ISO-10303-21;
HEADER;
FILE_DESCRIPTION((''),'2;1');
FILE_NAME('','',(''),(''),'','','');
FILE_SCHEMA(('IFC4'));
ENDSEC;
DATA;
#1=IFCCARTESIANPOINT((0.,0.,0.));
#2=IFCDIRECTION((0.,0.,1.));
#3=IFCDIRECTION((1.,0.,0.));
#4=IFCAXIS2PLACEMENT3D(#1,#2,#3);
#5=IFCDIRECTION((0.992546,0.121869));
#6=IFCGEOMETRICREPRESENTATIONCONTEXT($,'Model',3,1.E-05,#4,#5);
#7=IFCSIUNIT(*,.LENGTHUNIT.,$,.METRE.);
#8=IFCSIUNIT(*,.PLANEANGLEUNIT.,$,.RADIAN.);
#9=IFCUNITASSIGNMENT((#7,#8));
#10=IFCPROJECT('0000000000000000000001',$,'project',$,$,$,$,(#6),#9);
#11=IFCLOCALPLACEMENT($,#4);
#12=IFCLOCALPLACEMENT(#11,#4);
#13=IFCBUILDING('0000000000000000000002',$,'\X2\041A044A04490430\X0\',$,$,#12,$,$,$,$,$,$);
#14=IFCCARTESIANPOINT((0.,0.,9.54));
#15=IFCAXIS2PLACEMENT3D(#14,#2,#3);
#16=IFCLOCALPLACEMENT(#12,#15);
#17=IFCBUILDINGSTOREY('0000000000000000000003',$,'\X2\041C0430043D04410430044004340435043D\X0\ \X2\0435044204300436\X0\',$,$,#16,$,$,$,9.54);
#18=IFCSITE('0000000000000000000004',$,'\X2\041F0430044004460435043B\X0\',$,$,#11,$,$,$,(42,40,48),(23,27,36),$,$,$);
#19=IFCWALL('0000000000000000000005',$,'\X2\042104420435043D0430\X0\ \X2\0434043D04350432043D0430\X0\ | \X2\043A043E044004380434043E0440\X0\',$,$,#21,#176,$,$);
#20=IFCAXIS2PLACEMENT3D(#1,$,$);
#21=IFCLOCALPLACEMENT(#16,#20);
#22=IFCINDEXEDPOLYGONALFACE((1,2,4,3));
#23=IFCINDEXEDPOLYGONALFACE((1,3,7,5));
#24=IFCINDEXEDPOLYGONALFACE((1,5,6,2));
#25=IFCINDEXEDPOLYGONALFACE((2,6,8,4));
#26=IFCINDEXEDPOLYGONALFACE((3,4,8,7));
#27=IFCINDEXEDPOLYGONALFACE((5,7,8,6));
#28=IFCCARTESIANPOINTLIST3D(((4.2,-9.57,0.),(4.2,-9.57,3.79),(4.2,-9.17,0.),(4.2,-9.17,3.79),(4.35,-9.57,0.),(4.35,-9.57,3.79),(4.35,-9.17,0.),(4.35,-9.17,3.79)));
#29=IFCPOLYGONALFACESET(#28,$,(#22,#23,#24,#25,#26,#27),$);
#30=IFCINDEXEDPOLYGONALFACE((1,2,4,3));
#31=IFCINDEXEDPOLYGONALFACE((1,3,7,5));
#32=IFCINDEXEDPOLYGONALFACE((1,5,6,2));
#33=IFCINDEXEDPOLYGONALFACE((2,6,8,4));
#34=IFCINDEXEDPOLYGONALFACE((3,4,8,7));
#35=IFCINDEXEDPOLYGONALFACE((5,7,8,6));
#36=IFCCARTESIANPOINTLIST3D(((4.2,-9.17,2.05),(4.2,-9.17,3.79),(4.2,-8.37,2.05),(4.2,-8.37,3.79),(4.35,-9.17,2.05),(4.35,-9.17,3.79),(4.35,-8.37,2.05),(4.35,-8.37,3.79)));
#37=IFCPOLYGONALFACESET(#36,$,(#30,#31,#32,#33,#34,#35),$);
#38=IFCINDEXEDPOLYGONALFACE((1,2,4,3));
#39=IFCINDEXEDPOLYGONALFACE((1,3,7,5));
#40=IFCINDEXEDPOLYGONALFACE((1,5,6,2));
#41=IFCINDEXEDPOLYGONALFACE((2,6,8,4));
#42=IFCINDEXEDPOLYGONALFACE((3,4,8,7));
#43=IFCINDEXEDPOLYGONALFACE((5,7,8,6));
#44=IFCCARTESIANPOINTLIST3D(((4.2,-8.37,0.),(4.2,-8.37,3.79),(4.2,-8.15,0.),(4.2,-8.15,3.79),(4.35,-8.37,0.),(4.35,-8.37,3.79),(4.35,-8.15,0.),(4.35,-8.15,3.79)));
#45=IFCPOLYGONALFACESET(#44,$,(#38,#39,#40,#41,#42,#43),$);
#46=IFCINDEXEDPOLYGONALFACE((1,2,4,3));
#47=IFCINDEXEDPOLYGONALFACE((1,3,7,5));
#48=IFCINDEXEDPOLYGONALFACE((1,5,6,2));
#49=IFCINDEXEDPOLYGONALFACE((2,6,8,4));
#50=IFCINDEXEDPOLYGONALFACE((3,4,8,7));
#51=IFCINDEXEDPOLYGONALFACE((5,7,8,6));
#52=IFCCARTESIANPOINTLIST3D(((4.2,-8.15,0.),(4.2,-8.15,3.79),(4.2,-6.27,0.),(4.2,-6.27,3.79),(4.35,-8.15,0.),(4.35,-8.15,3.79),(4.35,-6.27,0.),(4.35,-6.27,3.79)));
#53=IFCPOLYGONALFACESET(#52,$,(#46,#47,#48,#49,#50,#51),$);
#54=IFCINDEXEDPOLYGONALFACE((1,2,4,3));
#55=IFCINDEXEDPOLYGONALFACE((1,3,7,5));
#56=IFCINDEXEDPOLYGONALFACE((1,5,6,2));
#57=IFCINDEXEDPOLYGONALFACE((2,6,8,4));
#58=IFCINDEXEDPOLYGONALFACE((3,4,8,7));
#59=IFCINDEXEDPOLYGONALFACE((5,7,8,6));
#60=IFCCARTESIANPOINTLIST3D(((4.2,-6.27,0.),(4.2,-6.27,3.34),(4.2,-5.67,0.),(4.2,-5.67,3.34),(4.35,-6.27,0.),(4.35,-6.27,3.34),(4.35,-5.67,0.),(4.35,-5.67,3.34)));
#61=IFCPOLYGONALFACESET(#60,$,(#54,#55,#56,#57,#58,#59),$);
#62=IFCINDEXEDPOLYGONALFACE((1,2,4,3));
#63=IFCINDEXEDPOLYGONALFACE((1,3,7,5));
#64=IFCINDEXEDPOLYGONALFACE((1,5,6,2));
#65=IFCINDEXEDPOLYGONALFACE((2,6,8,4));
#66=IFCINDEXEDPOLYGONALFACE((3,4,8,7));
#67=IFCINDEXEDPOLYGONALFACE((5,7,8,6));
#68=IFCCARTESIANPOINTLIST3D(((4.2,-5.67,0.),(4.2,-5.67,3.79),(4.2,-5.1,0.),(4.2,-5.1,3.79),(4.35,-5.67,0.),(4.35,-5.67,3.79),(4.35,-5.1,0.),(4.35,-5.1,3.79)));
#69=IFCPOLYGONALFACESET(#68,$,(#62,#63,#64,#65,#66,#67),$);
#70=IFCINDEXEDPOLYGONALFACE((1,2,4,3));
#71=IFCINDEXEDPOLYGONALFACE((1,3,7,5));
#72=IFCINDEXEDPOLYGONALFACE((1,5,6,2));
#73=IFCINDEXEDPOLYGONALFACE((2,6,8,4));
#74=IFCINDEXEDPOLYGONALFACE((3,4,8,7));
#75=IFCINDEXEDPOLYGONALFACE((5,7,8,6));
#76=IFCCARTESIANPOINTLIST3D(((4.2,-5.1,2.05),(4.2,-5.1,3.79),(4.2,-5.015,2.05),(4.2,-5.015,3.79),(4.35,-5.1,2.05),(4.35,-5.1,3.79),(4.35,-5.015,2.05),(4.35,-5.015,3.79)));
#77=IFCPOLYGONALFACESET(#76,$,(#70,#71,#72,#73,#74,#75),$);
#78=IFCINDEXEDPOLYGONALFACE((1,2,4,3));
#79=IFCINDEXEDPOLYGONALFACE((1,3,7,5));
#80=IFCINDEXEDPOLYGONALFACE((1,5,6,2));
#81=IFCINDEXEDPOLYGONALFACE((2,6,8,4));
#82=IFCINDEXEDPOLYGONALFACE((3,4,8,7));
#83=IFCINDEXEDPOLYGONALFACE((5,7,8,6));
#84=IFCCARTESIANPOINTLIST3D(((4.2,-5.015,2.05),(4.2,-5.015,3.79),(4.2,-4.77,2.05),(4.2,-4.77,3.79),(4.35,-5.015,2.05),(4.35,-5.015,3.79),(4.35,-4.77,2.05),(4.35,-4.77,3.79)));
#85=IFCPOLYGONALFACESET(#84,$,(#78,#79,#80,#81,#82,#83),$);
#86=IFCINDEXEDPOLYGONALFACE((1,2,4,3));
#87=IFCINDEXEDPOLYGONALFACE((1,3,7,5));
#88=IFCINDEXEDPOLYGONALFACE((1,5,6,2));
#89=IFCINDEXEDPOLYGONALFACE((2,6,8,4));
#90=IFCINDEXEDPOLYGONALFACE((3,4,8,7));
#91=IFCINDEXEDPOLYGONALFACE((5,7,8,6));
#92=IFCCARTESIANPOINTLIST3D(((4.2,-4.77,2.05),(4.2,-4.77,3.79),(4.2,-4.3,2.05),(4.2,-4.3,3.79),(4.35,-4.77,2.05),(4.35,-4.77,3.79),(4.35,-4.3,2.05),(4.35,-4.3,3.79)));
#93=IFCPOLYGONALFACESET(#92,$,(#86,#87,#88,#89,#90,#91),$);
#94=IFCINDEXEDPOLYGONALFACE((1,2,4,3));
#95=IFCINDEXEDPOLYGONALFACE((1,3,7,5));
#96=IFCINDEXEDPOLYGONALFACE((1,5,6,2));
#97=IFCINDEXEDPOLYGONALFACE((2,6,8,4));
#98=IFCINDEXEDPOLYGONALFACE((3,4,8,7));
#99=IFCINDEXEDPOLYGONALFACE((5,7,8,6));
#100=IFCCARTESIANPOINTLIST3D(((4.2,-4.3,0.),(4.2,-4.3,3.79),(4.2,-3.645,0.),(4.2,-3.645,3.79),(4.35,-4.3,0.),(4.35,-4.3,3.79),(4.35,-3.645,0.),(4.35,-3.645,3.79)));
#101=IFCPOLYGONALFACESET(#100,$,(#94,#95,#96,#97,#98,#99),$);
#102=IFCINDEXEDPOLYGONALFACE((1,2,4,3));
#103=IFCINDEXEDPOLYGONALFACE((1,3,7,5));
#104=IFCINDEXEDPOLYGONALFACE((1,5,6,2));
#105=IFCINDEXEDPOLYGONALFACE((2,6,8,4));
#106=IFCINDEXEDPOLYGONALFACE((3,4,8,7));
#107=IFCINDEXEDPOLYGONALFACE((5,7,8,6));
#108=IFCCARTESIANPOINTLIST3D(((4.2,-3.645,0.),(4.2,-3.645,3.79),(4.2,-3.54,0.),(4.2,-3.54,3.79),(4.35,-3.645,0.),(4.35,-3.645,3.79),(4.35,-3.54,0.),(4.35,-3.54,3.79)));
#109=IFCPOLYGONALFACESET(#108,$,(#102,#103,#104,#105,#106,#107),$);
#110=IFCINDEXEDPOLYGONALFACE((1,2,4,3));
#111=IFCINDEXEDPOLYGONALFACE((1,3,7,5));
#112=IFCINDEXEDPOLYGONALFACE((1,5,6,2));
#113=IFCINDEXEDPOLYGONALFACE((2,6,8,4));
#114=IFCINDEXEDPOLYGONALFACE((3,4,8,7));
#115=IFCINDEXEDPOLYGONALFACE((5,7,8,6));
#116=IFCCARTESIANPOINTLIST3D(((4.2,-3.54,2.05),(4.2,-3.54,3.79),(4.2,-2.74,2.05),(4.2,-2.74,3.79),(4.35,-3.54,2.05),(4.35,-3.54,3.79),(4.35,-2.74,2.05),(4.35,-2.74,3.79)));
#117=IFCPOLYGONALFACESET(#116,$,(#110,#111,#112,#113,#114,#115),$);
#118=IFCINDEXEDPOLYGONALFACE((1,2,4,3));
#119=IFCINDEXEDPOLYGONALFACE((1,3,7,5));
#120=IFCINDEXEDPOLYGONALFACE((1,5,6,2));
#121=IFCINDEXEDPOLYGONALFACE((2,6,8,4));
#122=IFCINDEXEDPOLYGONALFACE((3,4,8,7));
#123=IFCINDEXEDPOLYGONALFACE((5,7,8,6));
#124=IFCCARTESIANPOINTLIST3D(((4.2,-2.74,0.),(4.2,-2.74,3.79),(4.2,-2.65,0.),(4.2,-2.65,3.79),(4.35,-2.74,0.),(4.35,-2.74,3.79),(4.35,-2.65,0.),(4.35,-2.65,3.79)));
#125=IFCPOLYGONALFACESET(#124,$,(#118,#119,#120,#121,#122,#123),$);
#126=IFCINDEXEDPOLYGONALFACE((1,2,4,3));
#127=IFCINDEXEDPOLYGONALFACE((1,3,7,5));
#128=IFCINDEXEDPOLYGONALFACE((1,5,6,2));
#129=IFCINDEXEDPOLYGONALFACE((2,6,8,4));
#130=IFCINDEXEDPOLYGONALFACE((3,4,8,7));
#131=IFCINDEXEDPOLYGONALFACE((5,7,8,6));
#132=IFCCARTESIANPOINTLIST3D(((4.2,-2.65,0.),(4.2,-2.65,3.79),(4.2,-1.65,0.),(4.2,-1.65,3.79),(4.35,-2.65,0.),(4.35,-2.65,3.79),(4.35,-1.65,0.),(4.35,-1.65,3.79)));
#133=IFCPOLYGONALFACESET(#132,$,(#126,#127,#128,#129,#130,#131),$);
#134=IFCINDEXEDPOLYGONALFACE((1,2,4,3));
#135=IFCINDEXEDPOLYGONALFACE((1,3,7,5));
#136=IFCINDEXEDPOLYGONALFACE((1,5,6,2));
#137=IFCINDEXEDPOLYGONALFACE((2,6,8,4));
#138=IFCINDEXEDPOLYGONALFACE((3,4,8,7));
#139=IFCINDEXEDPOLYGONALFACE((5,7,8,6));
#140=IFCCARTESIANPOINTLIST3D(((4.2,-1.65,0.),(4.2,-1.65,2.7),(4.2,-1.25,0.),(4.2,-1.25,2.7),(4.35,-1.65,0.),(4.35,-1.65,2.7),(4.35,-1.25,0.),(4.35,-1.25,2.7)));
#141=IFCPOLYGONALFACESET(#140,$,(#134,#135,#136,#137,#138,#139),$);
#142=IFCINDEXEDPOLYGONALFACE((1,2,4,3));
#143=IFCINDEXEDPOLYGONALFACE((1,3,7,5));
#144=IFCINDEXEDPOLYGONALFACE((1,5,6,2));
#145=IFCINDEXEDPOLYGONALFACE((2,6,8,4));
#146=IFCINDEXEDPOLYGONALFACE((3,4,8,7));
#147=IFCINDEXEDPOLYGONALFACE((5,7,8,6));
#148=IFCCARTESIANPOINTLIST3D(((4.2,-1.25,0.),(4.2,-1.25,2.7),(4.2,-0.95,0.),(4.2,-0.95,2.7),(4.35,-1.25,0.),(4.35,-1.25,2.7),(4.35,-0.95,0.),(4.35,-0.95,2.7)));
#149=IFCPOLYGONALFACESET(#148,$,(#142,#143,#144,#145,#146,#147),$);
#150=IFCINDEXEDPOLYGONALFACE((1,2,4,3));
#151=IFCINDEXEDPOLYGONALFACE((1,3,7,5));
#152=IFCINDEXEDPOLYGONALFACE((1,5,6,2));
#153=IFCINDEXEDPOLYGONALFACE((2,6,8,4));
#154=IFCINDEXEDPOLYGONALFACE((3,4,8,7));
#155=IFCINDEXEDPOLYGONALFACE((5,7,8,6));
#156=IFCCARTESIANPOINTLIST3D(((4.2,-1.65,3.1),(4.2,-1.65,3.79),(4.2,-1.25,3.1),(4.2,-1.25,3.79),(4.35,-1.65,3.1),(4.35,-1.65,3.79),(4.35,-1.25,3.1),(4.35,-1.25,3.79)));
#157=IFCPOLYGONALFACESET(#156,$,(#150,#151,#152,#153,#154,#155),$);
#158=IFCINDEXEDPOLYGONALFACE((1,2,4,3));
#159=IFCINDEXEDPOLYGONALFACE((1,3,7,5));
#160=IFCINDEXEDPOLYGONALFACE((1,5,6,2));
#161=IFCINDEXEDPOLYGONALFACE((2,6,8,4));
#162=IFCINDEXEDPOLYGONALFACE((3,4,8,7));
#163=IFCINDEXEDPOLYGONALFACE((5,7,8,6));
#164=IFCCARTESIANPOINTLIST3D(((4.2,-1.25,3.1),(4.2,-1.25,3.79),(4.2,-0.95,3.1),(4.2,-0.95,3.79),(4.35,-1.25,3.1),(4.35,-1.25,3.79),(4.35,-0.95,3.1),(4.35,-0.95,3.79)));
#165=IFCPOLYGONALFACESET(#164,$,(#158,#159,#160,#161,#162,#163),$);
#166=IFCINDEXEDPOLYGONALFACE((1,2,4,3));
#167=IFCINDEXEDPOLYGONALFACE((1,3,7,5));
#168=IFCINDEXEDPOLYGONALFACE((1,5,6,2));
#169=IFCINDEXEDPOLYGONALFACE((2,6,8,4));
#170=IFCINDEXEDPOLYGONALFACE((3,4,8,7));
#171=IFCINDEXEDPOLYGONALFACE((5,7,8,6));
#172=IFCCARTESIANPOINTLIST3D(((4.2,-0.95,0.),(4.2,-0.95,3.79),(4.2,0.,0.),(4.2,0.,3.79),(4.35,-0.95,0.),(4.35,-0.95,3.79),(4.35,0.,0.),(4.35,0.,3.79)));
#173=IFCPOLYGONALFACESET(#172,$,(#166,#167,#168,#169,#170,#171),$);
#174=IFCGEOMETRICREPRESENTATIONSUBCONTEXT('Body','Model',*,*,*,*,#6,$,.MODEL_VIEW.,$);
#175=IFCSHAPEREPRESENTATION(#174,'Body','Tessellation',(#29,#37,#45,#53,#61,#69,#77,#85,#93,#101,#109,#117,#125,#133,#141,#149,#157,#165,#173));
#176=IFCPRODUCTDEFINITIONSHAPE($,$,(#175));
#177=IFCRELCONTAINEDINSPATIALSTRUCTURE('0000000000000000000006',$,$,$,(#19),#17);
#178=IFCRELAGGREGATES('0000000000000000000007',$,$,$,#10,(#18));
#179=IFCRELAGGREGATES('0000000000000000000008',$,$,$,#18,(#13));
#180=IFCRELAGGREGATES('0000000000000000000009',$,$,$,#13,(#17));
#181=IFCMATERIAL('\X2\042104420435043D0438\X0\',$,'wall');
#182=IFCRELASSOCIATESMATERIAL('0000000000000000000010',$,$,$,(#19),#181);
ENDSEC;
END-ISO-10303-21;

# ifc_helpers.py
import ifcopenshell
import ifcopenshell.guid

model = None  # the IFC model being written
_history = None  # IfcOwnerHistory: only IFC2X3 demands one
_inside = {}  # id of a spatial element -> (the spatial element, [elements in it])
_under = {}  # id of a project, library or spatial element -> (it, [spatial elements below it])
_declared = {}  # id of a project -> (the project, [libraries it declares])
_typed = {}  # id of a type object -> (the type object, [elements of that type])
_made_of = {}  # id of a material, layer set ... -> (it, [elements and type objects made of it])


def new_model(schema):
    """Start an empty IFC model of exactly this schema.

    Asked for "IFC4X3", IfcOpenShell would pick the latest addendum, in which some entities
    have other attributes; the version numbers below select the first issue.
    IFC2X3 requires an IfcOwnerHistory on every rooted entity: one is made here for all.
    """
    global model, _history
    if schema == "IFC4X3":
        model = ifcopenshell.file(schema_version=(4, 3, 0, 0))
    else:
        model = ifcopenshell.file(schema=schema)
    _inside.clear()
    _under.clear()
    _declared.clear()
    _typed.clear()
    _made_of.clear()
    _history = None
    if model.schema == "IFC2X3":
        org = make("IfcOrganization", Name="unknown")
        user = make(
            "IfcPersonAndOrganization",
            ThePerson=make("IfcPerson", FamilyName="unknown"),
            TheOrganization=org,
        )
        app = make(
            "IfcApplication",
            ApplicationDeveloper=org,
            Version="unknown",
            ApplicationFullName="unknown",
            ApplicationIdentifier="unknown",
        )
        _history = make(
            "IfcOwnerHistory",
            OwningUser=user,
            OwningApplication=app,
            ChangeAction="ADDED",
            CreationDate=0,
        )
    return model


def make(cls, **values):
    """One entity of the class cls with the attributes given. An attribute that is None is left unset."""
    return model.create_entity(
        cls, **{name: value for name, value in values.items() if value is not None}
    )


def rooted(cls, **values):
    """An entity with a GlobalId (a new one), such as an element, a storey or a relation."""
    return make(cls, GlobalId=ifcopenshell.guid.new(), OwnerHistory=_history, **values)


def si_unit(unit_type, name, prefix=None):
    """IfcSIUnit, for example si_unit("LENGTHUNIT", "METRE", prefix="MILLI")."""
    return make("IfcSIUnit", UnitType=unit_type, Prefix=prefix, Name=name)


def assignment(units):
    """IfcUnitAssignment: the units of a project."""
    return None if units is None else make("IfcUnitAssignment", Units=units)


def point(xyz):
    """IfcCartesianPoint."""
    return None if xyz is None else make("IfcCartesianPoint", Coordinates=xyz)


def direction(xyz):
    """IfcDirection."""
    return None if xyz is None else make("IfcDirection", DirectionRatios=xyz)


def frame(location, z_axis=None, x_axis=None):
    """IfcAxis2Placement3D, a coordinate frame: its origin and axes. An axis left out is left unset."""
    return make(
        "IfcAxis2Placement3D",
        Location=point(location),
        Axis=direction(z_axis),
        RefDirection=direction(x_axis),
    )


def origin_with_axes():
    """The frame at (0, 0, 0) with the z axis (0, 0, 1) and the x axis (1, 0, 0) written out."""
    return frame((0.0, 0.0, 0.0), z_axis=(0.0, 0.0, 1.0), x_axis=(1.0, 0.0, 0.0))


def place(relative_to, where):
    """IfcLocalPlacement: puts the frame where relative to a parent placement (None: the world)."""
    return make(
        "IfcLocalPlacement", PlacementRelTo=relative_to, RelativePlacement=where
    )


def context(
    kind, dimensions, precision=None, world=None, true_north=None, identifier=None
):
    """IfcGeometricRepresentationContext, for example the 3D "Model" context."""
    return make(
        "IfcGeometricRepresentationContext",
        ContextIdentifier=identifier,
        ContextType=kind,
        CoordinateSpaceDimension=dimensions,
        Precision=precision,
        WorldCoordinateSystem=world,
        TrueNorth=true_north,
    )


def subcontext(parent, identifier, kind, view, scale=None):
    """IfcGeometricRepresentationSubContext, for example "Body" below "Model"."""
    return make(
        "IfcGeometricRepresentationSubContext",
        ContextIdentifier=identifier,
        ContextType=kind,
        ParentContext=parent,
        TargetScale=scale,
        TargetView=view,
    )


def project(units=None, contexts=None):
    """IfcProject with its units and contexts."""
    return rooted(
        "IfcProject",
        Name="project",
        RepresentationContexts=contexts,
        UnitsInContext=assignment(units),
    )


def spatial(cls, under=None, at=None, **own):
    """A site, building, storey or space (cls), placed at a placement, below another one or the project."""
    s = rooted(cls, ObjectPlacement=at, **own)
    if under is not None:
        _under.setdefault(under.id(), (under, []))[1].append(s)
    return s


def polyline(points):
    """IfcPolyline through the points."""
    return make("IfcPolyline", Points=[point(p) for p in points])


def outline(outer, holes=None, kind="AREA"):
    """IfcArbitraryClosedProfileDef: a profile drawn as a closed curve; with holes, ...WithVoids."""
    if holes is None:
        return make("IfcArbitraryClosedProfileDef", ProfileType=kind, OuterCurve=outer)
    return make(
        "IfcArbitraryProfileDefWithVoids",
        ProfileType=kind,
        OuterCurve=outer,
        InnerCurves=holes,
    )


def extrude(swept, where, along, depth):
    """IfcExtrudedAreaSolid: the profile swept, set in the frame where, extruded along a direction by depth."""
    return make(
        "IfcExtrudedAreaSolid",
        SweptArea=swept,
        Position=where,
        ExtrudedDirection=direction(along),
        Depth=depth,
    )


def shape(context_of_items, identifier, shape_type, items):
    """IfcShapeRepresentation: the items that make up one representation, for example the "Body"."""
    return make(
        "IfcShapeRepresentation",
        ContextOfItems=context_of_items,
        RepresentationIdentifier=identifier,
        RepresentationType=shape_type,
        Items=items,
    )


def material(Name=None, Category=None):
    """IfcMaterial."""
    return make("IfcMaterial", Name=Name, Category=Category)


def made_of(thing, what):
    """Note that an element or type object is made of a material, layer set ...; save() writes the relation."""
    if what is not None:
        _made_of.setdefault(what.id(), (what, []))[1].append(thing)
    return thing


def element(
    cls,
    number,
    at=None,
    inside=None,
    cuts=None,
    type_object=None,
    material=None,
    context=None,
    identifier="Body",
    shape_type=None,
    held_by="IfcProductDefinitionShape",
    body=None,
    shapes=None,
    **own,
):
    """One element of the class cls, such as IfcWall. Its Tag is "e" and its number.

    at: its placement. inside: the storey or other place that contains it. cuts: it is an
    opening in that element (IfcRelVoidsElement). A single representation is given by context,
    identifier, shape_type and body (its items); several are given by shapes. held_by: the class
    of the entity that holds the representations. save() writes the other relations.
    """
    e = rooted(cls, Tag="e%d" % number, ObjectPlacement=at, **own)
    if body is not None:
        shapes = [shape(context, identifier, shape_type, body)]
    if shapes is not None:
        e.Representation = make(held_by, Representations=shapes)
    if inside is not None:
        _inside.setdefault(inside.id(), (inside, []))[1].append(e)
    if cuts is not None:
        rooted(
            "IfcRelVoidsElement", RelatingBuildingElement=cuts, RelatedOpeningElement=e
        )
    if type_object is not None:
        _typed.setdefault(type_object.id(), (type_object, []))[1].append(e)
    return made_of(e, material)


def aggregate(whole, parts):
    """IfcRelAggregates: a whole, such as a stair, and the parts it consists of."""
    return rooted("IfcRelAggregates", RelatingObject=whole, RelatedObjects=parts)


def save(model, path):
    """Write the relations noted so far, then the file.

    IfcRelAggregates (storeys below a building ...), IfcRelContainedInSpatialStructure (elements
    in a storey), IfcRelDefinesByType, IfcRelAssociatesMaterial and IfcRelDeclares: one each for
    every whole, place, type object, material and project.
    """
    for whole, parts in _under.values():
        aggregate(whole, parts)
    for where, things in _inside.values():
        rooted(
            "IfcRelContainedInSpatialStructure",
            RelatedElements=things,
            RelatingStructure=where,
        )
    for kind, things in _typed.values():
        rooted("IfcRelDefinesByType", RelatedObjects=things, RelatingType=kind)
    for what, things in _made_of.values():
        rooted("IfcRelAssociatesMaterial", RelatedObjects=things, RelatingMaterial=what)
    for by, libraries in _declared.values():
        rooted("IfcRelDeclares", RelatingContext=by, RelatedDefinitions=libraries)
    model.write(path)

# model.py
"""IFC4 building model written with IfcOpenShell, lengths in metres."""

from ifc_helpers import new_model, si_unit, direction, frame, origin_with_axes, place, context, subcontext, project, spatial, polyline, outline, extrude, material, element, save


model = new_model("IFC4")

# Units and contexts
model_context = context("Model", 3, precision=1e-05, world=origin_with_axes(), true_north=direction((0.992546, 0.121869)))
body_context = subcontext(model_context, "Body", "Model", "MODEL_VIEW")
ifc_project = project(units=[si_unit("LENGTHUNIT", "METRE"), si_unit("PLANEANGLEUNIT", "RADIAN")], contexts=[model_context])

# Site, building, storey
site_placement = place(None, origin_with_axes())
site = spatial("IfcSite", under=ifc_project, at=site_placement, Name="Парцел", RefLatitude=(42, 40, 48), RefLongitude=(23, 27, 36))
building_placement = place(site_placement, origin_with_axes())
building = spatial("IfcBuilding", under=site, at=building_placement, Name="Къща")
storey_placement = place(building_placement, frame((0.0, 0.0, 9.54), z_axis=(0.0, 0.0, 1.0), x_axis=(1.0, 0.0, 0.0)))
storey = spatial("IfcBuildingStorey", under=building, at=storey_placement, Name="Мансарден етаж", Elevation=9.54)

# Wall
ifc_material_1 = material(Name="Стени", Category="wall")
wall_1_placement = place(storey_placement, origin_with_axes())
element("IfcWall", 1, at=wall_1_placement, inside=storey, material=ifc_material_1, Name="Стена дневна | коридор", context=body_context, shape_type="SweptSolid", body=[
    extrude(outline(polyline([(4.2, 0.0), (4.35, 0.0), (4.35, -3.79), (4.2, -3.79), (4.2, 0.0)])), frame((0.0, -9.57, 0.0), z_axis=(0.0, 1.0, 0.0), x_axis=(1.0, 0.0, 0.0)), (0.0, 0.0, 1.0), 0.4),
    extrude(outline(polyline([(4.2, -2.05), (4.35, -2.05), (4.35, -3.79), (4.2, -3.79), (4.2, -2.05)])), frame((0.0, -9.17, 0.0), z_axis=(0.0, 1.0, 0.0), x_axis=(1.0, 0.0, 0.0)), (0.0, 0.0, 1.0), 0.8),
    extrude(outline(polyline([(4.2, 0.0), (4.35, 0.0), (4.35, -3.79), (4.2, -3.79), (4.2, 0.0)])), frame((0.0, -8.37, 0.0), z_axis=(0.0, 1.0, 0.0), x_axis=(1.0, 0.0, 0.0)), (0.0, 0.0, 1.0), 0.22),
    extrude(outline(polyline([(4.2, 0.0), (4.35, 0.0), (4.35, -3.79), (4.2, -3.79), (4.2, 0.0)])), frame((0.0, -8.15, 0.0), z_axis=(0.0, 1.0, 0.0), x_axis=(1.0, 0.0, 0.0)), (0.0, 0.0, 1.0), 1.88),
    extrude(outline(polyline([(4.2, 0.0), (4.35, 0.0), (4.35, -3.34), (4.2, -3.34), (4.2, 0.0)])), frame((0.0, -6.27, 0.0), z_axis=(0.0, 1.0, 0.0), x_axis=(1.0, 0.0, 0.0)), (0.0, 0.0, 1.0), 0.6),
    extrude(outline(polyline([(4.2, 0.0), (4.35, 0.0), (4.35, -3.79), (4.2, -3.79), (4.2, 0.0)])), frame((0.0, -5.67, 0.0), z_axis=(0.0, 1.0, 0.0), x_axis=(1.0, 0.0, 0.0)), (0.0, 0.0, 1.0), 0.57),
    extrude(outline(polyline([(4.2, -2.05), (4.35, -2.05), (4.35, -3.79), (4.2, -3.79), (4.2, -2.05)])), frame((0.0, -5.1, 0.0), z_axis=(0.0, 1.0, 0.0), x_axis=(1.0, 0.0, 0.0)), (0.0, 0.0, 1.0), 0.085),
    extrude(outline(polyline([(4.2, -2.05), (4.35, -2.05), (4.35, -3.79), (4.2, -3.79), (4.2, -2.05)])), frame((0.0, -5.015, 0.0), z_axis=(0.0, 1.0, 0.0), x_axis=(1.0, 0.0, 0.0)), (0.0, 0.0, 1.0), 0.245),
    extrude(outline(polyline([(4.2, -2.05), (4.35, -2.05), (4.35, -3.79), (4.2, -3.79), (4.2, -2.05)])), frame((0.0, -4.77, 0.0), z_axis=(0.0, 1.0, 0.0), x_axis=(1.0, 0.0, 0.0)), (0.0, 0.0, 1.0), 0.47),
    extrude(outline(polyline([(4.2, 0.0), (4.35, 0.0), (4.35, -3.79), (4.2, -3.79), (4.2, 0.0)])), frame((0.0, -4.3, 0.0), z_axis=(0.0, 1.0, 0.0), x_axis=(1.0, 0.0, 0.0)), (0.0, 0.0, 1.0), 0.655),
    extrude(outline(polyline([(4.2, 0.0), (4.35, 0.0), (4.35, -3.79), (4.2, -3.79), (4.2, 0.0)])), frame((0.0, -3.645, 0.0), z_axis=(0.0, 1.0, 0.0), x_axis=(1.0, 0.0, 0.0)), (0.0, 0.0, 1.0), 0.105),
    extrude(outline(polyline([(4.2, -2.05), (4.35, -2.05), (4.35, -3.79), (4.2, -3.79), (4.2, -2.05)])), frame((0.0, -3.54, 0.0), z_axis=(0.0, 1.0, 0.0), x_axis=(1.0, 0.0, 0.0)), (0.0, 0.0, 1.0), 0.8),
    extrude(outline(polyline([(4.2, 0.0), (4.35, 0.0), (4.35, -3.79), (4.2, -3.79), (4.2, 0.0)])), frame((0.0, -2.74, 0.0), z_axis=(0.0, 1.0, 0.0), x_axis=(1.0, 0.0, 0.0)), (0.0, 0.0, 1.0), 0.09),
    extrude(outline(polyline([(4.2, 0.0), (4.35, 0.0), (4.35, -3.79), (4.2, -3.79), (4.2, 0.0)])), frame((0.0, -2.65, 0.0), z_axis=(0.0, 1.0, 0.0), x_axis=(1.0, 0.0, 0.0)), (0.0, 0.0, 1.0), 1.0),
    extrude(outline(polyline([(4.2, 0.0), (4.35, 0.0), (4.35, -2.7), (4.2, -2.7), (4.2, 0.0)])), frame((0.0, -1.65, 0.0), z_axis=(0.0, 1.0, 0.0), x_axis=(1.0, 0.0, 0.0)), (0.0, 0.0, 1.0), 0.4),
    extrude(outline(polyline([(4.2, 0.0), (4.35, 0.0), (4.35, -2.7), (4.2, -2.7), (4.2, 0.0)])), frame((0.0, -1.25, 0.0), z_axis=(0.0, 1.0, 0.0), x_axis=(1.0, 0.0, 0.0)), (0.0, 0.0, 1.0), 0.3),
    extrude(outline(polyline([(4.2, -3.1), (4.35, -3.1), (4.35, -3.79), (4.2, -3.79), (4.2, -3.1)])), frame((0.0, -1.65, 0.0), z_axis=(0.0, 1.0, 0.0), x_axis=(1.0, 0.0, 0.0)), (0.0, 0.0, 1.0), 0.4),
    extrude(outline(polyline([(4.2, -3.1), (4.35, -3.1), (4.35, -3.79), (4.2, -3.79), (4.2, -3.1)])), frame((0.0, -1.25, 0.0), z_axis=(0.0, 1.0, 0.0), x_axis=(1.0, 0.0, 0.0)), (0.0, 0.0, 1.0), 0.3),
    extrude(outline(polyline([(4.2, 0.0), (4.35, 0.0), (4.35, -3.79), (4.2, -3.79), (4.2, 0.0)])), frame((0.0, -0.95, 0.0), z_axis=(0.0, 1.0, 0.0), x_axis=(1.0, 0.0, 0.0)), (0.0, 0.0, 1.0), 0.95),
])

save(model, "model.ifc")
